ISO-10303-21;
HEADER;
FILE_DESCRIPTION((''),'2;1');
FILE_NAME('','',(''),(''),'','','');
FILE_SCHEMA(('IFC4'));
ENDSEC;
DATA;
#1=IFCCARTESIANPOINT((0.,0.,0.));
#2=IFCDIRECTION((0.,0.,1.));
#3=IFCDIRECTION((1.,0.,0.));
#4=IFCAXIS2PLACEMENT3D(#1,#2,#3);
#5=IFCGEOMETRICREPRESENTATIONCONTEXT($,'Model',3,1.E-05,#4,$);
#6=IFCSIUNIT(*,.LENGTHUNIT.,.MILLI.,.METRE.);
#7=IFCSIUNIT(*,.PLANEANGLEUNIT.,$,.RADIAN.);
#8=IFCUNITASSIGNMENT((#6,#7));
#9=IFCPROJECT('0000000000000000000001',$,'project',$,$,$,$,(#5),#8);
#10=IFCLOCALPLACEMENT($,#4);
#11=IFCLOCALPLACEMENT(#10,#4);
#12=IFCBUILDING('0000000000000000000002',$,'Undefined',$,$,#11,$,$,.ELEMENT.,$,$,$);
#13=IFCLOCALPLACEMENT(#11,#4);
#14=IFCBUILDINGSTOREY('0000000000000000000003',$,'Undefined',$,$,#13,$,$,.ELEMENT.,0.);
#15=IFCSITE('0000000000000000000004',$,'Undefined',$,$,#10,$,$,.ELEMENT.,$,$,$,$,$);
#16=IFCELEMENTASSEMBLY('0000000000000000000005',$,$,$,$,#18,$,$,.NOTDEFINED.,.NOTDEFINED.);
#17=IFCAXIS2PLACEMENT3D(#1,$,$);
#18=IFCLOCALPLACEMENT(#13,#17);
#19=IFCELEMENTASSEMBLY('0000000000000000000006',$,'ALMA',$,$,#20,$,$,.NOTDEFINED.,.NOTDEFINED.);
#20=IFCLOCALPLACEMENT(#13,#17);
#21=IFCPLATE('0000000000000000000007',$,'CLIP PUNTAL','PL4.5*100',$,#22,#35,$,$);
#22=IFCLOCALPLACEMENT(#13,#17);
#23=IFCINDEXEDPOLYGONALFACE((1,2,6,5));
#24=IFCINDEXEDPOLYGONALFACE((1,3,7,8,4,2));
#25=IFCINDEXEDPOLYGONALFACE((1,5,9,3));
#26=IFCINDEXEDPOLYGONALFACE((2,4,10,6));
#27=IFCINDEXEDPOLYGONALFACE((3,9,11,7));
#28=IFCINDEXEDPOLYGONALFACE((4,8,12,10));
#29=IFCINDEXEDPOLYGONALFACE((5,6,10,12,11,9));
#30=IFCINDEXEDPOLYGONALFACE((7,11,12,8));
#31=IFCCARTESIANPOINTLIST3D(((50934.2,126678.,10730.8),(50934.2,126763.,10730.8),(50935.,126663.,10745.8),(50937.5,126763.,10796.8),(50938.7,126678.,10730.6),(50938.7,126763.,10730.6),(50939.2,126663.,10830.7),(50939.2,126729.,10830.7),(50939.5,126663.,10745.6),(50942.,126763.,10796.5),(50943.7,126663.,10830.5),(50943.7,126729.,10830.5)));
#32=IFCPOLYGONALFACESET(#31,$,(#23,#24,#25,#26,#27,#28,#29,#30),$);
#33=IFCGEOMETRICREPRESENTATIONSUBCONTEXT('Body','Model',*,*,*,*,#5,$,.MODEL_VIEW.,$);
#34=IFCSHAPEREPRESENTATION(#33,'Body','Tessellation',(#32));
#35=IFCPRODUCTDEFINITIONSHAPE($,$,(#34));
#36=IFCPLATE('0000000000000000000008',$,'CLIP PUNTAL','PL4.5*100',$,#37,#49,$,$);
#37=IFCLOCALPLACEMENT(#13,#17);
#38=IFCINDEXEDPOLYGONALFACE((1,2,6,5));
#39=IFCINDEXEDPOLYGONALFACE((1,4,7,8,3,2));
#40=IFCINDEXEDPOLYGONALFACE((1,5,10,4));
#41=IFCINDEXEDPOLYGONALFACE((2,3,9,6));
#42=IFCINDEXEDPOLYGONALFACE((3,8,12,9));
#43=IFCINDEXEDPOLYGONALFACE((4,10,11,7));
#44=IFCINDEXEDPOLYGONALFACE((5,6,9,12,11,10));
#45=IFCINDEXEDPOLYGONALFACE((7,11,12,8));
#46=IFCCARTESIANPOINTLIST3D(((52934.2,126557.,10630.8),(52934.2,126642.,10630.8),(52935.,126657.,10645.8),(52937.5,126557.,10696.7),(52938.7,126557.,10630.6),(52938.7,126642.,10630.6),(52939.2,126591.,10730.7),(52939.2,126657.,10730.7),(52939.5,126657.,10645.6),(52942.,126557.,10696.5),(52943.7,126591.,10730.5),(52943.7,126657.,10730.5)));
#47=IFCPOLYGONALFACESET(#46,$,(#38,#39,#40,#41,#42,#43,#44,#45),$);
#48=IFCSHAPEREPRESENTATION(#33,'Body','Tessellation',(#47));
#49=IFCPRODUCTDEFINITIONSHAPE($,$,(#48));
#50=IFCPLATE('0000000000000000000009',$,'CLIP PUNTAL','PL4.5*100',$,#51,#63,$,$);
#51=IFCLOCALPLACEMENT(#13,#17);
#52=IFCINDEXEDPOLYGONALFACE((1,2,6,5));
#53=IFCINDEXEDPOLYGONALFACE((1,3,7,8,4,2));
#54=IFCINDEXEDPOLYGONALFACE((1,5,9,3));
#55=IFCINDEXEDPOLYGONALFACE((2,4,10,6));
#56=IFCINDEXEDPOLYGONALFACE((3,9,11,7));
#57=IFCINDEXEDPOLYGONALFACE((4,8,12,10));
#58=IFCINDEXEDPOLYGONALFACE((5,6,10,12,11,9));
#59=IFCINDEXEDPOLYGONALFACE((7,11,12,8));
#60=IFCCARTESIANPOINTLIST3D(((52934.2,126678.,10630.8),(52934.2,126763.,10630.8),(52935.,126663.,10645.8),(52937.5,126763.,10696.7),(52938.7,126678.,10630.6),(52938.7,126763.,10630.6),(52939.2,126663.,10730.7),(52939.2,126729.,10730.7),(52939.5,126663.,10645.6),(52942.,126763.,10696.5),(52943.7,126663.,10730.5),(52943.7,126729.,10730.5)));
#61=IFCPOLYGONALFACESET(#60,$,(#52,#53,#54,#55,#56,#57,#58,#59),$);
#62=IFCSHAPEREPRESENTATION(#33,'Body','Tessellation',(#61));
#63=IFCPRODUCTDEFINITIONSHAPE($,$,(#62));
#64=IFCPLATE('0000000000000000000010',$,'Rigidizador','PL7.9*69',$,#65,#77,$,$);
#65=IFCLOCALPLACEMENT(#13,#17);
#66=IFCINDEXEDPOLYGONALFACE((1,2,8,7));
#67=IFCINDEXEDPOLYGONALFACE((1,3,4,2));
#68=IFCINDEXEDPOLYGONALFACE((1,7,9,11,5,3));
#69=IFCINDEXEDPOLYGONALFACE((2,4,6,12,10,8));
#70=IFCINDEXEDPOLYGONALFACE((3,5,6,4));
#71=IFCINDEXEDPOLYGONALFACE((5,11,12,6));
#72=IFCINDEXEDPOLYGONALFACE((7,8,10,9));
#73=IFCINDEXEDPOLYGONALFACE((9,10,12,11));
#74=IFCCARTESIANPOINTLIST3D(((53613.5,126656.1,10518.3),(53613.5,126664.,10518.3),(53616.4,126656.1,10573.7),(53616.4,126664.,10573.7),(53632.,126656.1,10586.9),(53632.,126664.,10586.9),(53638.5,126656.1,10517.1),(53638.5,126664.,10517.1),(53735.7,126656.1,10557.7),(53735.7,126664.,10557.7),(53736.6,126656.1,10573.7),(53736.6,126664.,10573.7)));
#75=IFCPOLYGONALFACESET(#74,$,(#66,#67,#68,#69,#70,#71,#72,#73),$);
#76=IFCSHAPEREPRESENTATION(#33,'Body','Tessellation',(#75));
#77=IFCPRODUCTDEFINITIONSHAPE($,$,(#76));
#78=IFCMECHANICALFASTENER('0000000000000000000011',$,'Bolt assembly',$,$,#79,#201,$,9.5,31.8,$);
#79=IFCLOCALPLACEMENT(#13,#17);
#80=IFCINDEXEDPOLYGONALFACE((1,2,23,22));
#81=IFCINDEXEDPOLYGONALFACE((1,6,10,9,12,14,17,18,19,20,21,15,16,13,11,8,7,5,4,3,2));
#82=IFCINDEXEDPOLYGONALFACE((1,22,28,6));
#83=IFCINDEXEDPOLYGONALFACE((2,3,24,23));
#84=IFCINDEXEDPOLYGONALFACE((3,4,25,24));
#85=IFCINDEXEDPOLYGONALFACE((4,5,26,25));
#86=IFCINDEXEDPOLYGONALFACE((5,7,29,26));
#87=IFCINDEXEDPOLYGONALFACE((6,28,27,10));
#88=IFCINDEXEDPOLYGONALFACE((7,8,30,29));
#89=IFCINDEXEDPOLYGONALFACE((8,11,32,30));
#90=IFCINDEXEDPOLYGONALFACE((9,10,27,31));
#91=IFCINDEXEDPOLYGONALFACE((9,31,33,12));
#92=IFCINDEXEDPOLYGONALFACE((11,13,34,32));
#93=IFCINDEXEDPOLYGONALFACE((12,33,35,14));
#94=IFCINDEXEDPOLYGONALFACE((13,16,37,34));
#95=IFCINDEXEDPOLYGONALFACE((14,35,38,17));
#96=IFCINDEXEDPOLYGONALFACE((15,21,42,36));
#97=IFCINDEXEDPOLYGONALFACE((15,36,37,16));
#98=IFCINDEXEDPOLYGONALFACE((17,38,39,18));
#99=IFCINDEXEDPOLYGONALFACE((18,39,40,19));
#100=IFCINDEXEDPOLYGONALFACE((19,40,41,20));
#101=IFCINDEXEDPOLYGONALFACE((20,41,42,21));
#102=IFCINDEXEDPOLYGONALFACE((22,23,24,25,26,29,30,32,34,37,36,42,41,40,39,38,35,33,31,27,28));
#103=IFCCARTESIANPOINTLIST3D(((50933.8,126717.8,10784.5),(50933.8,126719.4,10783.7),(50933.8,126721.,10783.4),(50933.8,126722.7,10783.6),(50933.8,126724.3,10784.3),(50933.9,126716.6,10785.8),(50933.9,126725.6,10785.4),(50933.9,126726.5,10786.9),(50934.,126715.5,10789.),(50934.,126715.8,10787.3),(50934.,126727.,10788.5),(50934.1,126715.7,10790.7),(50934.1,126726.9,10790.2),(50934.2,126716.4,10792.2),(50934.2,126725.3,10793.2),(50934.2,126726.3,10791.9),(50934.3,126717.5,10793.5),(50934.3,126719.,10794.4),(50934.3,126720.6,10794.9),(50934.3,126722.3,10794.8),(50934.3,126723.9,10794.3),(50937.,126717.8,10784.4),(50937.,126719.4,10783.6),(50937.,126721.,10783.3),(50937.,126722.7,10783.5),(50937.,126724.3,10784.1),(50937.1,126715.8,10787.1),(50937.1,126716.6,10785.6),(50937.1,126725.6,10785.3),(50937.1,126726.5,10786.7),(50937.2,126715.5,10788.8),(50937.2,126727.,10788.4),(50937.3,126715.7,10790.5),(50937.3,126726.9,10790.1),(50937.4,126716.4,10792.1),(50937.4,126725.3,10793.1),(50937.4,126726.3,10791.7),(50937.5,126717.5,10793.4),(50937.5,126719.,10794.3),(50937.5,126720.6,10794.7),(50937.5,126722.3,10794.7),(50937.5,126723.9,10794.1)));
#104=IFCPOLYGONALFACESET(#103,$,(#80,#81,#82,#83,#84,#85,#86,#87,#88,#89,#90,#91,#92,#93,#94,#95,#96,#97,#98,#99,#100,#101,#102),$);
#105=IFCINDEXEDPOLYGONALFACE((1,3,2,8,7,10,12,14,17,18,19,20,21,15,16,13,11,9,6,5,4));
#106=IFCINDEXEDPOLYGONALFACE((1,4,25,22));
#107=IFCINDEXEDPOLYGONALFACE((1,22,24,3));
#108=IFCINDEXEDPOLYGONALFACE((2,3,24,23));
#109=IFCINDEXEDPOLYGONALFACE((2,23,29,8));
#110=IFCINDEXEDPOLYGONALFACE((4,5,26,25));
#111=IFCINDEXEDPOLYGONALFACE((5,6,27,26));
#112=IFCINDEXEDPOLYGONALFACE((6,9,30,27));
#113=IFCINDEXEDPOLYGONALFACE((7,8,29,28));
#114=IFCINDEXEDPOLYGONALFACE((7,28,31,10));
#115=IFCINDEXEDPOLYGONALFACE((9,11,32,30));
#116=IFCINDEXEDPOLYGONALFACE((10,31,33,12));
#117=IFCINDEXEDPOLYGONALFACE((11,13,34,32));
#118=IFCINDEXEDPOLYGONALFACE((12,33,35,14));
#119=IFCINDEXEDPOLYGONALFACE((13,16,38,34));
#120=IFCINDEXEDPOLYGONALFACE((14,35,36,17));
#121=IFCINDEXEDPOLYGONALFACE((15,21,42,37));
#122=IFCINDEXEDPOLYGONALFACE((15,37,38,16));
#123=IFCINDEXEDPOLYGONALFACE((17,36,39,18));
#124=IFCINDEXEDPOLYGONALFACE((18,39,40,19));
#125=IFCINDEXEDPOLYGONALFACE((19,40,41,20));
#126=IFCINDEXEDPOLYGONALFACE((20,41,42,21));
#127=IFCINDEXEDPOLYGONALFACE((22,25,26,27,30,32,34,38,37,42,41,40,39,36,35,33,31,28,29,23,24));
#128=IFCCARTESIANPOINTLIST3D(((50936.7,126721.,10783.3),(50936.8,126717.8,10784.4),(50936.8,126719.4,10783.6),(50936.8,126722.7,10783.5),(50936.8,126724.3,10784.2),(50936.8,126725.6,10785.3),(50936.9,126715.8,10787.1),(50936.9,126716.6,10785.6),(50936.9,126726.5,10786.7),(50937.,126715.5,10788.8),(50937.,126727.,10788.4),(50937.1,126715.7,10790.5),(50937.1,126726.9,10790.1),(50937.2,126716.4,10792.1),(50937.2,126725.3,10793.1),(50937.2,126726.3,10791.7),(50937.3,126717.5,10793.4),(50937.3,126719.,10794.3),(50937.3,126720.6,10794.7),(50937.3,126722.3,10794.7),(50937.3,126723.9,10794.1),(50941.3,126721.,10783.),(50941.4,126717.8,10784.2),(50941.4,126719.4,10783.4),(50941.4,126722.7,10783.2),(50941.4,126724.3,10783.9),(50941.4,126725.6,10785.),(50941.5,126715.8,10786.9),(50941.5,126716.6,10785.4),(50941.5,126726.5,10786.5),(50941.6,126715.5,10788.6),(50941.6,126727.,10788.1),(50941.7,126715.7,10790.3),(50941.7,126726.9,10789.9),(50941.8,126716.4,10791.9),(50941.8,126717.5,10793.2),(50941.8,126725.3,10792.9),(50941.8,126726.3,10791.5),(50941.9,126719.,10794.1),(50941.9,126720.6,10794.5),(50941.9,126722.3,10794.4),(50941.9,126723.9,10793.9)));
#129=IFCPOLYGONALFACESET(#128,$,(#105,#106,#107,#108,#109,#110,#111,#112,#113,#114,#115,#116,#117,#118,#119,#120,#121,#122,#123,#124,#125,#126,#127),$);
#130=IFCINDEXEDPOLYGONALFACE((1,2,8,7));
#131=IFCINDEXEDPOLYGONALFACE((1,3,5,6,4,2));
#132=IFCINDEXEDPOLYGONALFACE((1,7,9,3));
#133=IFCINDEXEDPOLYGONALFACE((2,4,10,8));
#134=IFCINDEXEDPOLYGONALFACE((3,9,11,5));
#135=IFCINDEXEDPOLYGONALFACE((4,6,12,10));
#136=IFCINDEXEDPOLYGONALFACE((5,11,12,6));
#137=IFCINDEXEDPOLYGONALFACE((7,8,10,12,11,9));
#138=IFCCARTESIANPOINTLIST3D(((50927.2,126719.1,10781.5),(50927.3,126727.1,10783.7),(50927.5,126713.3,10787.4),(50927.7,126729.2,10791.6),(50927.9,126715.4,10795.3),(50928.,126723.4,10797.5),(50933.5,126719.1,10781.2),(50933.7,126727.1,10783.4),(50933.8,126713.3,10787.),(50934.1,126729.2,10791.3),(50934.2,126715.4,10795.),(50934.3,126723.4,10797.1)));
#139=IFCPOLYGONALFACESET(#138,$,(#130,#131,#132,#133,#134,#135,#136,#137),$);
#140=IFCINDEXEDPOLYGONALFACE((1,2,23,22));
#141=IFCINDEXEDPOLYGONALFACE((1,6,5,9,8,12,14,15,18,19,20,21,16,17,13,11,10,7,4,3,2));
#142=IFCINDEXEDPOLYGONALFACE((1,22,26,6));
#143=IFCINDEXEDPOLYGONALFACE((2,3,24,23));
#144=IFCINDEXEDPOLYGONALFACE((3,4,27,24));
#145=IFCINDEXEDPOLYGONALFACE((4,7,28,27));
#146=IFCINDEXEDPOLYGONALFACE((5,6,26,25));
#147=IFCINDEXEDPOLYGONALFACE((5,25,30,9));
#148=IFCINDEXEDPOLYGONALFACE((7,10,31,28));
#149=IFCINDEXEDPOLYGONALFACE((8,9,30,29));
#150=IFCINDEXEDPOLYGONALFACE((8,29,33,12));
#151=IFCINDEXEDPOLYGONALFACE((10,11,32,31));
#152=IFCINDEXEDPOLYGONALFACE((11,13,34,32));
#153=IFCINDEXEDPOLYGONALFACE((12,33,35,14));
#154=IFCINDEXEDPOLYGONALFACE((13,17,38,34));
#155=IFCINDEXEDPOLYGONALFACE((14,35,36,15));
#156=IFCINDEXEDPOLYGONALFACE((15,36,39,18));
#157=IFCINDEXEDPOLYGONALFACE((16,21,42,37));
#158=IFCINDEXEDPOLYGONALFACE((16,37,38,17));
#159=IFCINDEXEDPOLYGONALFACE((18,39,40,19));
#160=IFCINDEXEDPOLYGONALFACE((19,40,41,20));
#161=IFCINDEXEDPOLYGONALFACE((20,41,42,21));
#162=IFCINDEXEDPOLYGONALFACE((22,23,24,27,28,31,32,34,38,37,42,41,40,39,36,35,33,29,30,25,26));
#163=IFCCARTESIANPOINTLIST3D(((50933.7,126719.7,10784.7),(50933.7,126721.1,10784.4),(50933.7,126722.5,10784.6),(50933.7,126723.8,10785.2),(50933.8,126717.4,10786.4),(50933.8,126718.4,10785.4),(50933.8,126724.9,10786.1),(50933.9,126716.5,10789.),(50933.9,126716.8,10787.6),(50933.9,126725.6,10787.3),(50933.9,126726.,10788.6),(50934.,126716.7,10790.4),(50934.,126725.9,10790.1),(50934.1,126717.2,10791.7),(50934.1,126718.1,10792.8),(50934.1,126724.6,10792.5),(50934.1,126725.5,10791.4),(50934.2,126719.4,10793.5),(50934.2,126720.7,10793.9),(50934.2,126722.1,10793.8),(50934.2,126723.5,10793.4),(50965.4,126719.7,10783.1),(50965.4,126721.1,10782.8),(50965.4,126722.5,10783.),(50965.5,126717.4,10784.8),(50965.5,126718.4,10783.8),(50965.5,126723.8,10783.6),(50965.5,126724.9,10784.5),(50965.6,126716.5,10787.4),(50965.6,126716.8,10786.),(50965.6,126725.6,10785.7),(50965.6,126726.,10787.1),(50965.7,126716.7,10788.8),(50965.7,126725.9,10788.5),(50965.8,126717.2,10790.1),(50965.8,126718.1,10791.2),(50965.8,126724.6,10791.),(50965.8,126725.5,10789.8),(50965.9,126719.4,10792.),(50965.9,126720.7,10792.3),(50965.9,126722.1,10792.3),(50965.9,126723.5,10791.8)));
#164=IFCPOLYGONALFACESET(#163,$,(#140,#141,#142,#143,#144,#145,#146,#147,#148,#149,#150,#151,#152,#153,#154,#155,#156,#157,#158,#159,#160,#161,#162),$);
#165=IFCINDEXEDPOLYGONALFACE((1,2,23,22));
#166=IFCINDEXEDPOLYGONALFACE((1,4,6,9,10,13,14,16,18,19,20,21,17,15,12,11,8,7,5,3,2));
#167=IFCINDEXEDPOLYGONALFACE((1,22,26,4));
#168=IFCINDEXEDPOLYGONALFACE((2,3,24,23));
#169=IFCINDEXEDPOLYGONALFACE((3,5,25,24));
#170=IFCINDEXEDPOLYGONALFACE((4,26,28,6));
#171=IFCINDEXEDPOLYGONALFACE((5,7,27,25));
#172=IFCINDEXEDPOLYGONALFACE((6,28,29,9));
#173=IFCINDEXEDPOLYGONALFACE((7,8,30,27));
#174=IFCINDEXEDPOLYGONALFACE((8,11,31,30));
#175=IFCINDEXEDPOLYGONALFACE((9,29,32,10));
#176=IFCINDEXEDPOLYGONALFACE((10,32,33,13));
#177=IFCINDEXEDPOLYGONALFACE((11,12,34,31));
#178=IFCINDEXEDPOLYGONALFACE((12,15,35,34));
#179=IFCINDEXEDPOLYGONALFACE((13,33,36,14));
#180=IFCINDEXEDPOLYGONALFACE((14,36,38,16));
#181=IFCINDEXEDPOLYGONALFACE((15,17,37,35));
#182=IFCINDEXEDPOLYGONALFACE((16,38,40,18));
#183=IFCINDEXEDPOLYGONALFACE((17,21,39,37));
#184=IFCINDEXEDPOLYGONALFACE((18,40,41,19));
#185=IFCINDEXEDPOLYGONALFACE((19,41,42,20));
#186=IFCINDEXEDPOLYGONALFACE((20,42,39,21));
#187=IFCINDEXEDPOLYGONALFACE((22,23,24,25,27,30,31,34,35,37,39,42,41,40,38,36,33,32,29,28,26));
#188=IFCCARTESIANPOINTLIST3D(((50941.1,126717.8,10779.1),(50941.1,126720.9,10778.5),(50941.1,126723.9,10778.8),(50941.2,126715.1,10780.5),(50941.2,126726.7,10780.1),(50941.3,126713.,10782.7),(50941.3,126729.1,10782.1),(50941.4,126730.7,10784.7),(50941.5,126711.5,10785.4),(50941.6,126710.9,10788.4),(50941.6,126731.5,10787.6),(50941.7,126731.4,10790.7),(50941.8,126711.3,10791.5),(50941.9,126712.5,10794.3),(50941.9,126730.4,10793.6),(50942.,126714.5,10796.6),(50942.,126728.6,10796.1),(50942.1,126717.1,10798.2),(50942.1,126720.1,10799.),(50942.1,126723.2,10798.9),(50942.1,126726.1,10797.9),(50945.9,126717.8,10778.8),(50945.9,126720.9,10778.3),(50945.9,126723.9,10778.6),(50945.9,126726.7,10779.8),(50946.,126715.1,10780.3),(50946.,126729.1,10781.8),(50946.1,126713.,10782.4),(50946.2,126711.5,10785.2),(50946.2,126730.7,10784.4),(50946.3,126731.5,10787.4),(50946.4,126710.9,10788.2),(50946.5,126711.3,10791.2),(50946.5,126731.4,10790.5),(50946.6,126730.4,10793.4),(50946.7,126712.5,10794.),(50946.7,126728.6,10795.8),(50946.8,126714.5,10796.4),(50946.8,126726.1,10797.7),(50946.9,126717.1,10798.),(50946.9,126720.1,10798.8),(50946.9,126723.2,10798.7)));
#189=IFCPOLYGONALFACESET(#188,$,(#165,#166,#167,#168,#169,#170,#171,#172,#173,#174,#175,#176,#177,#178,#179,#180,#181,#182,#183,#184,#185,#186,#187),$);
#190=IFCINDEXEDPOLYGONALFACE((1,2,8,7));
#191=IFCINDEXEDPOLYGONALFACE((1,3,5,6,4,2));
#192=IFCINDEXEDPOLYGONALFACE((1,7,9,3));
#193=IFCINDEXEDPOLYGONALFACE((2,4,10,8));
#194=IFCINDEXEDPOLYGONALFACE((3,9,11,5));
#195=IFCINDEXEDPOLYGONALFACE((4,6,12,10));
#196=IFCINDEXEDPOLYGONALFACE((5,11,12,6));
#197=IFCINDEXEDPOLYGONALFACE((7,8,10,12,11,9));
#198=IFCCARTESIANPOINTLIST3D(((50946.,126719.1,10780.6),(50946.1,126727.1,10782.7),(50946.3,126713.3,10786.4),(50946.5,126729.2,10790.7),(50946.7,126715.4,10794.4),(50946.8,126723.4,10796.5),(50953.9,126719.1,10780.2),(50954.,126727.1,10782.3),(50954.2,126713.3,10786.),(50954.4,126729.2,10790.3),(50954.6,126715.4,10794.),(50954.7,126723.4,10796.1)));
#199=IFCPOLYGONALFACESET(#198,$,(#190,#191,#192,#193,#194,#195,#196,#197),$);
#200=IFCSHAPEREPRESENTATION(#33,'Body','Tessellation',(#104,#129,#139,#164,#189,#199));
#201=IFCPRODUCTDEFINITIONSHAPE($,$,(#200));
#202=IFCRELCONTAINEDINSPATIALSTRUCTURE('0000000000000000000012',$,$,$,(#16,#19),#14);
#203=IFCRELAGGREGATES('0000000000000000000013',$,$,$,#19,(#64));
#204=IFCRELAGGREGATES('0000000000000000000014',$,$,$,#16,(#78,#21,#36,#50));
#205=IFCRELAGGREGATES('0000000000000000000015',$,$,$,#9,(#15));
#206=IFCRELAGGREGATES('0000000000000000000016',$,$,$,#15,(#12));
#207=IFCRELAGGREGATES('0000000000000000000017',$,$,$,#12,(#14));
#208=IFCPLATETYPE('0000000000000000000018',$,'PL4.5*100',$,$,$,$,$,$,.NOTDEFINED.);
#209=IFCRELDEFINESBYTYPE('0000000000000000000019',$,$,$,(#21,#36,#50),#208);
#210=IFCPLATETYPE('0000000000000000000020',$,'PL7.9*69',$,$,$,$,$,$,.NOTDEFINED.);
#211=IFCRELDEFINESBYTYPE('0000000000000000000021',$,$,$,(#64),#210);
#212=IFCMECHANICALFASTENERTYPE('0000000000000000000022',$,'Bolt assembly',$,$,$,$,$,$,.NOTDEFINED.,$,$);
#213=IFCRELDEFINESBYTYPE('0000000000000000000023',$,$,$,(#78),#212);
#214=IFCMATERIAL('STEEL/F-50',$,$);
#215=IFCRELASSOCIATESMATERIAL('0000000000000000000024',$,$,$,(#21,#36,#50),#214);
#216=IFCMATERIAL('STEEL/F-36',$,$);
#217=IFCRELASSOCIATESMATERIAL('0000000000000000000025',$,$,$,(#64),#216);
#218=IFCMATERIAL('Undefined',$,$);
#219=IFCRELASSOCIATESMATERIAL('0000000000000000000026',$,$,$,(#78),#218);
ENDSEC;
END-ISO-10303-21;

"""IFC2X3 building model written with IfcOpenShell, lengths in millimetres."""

from ifc_helpers import new_model, si_unit, frame, origin_with_axes, origin_2d_with_axis, place, context, subcontext, project, spatial, polyline, circle, outline, extrude, source, transform, mapped, material, type_object, element, aggregate, save


model = new_model("IFC2X3")

# Units and contexts
model_context = context("Model", 3, precision=1e-05, world=origin_with_axes())
body_context = subcontext(model_context, "Body", "Model", "MODEL_VIEW")
ifc_project = project(units=[si_unit("LENGTHUNIT", "METRE", prefix="MILLI"), si_unit("PLANEANGLEUNIT", "RADIAN")], contexts=[model_context])

# Site, building, storey
site_placement = place(None, origin_with_axes())
site = spatial("IfcSite", under=ifc_project, at=site_placement, Name="Undefined", CompositionType="ELEMENT")
building_placement = place(site_placement, origin_with_axes())
building = spatial("IfcBuilding", under=site, at=building_placement, Name="Undefined", CompositionType="ELEMENT")
storey_placement = place(building_placement, origin_with_axes())
storey = spatial("IfcBuildingStorey", under=building, at=storey_placement, Name="Undefined", CompositionType="ELEMENT", Elevation=0.0)

# Element assemblies
assembly_1_placement = place(storey_placement, origin_with_axes())
assembly_1 = element("IfcElementAssembly", 1, at=assembly_1_placement, inside=storey, AssemblyPlace="NOTDEFINED", PredefinedType="NOTDEFINED")
ifc_material_1 = material(Name="STEEL/F-36")
assembly_2_placement = place(storey_placement, origin_with_axes())
assembly_2 = element("IfcElementAssembly", 2, at=assembly_2_placement, inside=storey, Name="ALMA", AssemblyPlace="NOTDEFINED", PredefinedType="NOTDEFINED")

# Shared definitions
ifc_material_2 = material(Name="STEEL/F-50")

# Plates
plate_type_1 = type_object("IfcPlateType", Name="PL4.5*100", PredefinedType="NOTDEFINED")
plate_1_placement = place(assembly_1_placement, frame((50941.5, 126663.0, 10830.6), z_axis=(-0.998754, 0.0, 0.049896), x_axis=(0.0, 1.0, 0.0)))
plate_1 = element("IfcPlate", 3, at=plate_1_placement, type_object=plate_type_1, material=ifc_material_2, Name="CLIP PUNTAL", Description="PL4.5*100", context=body_context, shape_type="SweptSolid", body=[
    extrude(outline(polyline([(0.0, 0.0), (66.0, 0.0), (100.0, 34.0), (100.0, 100.0), (15.0, 100.0), (0.0, 85.0), (0.0, 0.0)])), frame((0.0, 0.0, -2.2), z_axis=(0.0, 0.0, 1.0), x_axis=(1.0, 0.0, 0.0)), (0.0, 0.0, 1.0), 4.5),
])
plate_2_placement = place(assembly_1_placement, frame((52941.5, 126657.0, 10730.6), z_axis=(0.998754, 0.0, -0.049896), x_axis=(0.0, -1.0, 0.0)))
plate_2 = element("IfcPlate", 4, at=plate_2_placement, type_object=plate_type_1, material=ifc_material_2, Name="CLIP PUNTAL", Description="PL4.5*100", context=body_context, shape_type="SweptSolid", body=[
    extrude(outline(polyline([(0.0, 0.0), (66.0, 0.0), (100.0, 34.0), (100.0, 100.0), (15.0, 100.0), (0.0, 85.0), (0.0, 0.0)])), frame((0.0, 0.0, -2.2), z_axis=(0.0, 0.0, 1.0), x_axis=(1.0, 0.0, 0.0)), (0.0, 0.0, 1.0), 4.5),
])
plate_3_placement = place(assembly_1_placement, frame((52941.5, 126663.0, 10730.6), z_axis=(-0.998754, 0.0, 0.049896), x_axis=(0.0, 1.0, 0.0)))
plate_3 = element("IfcPlate", 5, at=plate_3_placement, type_object=plate_type_1, material=ifc_material_2, Name="CLIP PUNTAL", Description="PL4.5*100", context=body_context, shape_type="SweptSolid", body=[
    extrude(outline(polyline([(0.0, 0.0), (66.0, 0.0), (100.0, 34.0), (100.0, 100.0), (15.0, 100.0), (0.0, 85.0), (0.0, 0.0)])), frame((0.0, 0.0, -2.2), z_axis=(0.0, 0.0, 1.0), x_axis=(1.0, 0.0, 0.0)), (0.0, 0.0, 1.0), 4.5),
])
plate_type_2 = type_object("IfcPlateType", Name="PL7.9*69", PredefinedType="NOTDEFINED")
plate_4_placement = place(assembly_2_placement, frame((53613.5, 126660.0, 10518.3), z_axis=(0.0, 1.0, 0.0), x_axis=(0.051067, 0.0, 0.998695)))
plate_4 = element("IfcPlate", 6, at=plate_4_placement, type_object=plate_type_2, material=ifc_material_1, Name="Rigidizador", Description="PL7.9*69", context=body_context, shape_type="SweptSolid", body=[
    extrude(outline(polyline([(0.0, 0.0), (55.6, 0.0), (69.4, 15.0), (61.7, 120.0), (45.6, 120.0), (0.1, 25.0), (0.0, 0.0)])), frame((0.0, 0.0, -4.0), z_axis=(0.0, 0.0, 1.0), x_axis=(1.0, 0.0, 0.0)), (0.0, 0.0, 1.0), 7.9),
])

# Shared definitions
ifc_material_3 = material(Name="Undefined")
mechanical_fastener_type = type_object("IfcMechanicalFastenerType", Name="Bolt assembly")
aggregate(assembly_2, [plate_4])

# Mechanical fastener
shared_shape_1 = source(origin_with_axes(), body_context, "Body", "SweptSolid", [
    extrude(circle(Radius=5.8, at=origin_2d_with_axis()), frame((0.0, -7.6, 0.0), z_axis=(0.0, 1.0, 0.0), x_axis=(1.0, 0.0, 0.0)), (0.0, 0.0, 1.0), 3.2),
    extrude(circle(Radius=5.8, at=origin_2d_with_axis()), frame((0.0, -4.6, 0.0), z_axis=(0.0, 1.0, 0.0), x_axis=(1.0, 0.0, 0.0)), (0.0, 0.0, 1.0), 4.6),
    extrude(outline(polyline([(7.1, -4.1), (7.1, 4.1), (0.0, 8.2), (-7.1, 4.1), (-7.1, -4.1), (0.0, -8.2), (7.1, -4.1)])), frame((0.0, -14.0, 0.0), z_axis=(0.0, 1.0, 0.0), x_axis=(1.0, 0.0, 0.0)), (0.0, 0.0, 1.0), 6.3),
    extrude(circle(Radius=4.8, at=origin_2d_with_axis()), frame((0.0, -7.7, 0.0), z_axis=(0.0, 1.0, 0.0), x_axis=(1.0, 0.0, 0.0)), (0.0, 0.0, 1.0), 31.8),
    extrude(circle(Radius=10.3, at=origin_2d_with_axis()), frame((0.0, 0.0, 0.0), z_axis=(0.0, 1.0, 0.0), x_axis=(1.0, 0.0, 0.0)), (0.0, 0.0, 1.0), 4.8),
    extrude(outline(polyline([(7.1, -4.1), (7.1, 4.1), (0.0, 8.2), (-7.1, 4.1), (-7.1, -4.1), (0.0, -8.2), (7.1, -4.1)])), frame((0.0, 4.8, 0.0), z_axis=(0.0, 1.0, 0.0), x_axis=(1.0, 0.0, 0.0)), (0.0, 0.0, 1.0), 7.9),
])
mechanical_fastener_1_placement = place(assembly_1_placement, frame((50941.6, 126721.3, 10788.8), z_axis=(-0.035282, 0.707107, -0.706226), x_axis=(0.035281, 0.707107, 0.706226)))
mechanical_fastener_1 = element("IfcMechanicalFastener", 7, at=mechanical_fastener_1_placement, type_object=mechanical_fastener_type, material=ifc_material_3, Name="Bolt assembly", NominalDiameter=9.5, NominalLength=31.8, context=body_context, shape_type="MappedRepresentation", body=[
    mapped(shared_shape_1, transform((0.0, 0.0, 0.0))),
])
aggregate(assembly_1, [mechanical_fastener_1, plate_1, plate_2, plate_3])

save(model, "model.ifc")
